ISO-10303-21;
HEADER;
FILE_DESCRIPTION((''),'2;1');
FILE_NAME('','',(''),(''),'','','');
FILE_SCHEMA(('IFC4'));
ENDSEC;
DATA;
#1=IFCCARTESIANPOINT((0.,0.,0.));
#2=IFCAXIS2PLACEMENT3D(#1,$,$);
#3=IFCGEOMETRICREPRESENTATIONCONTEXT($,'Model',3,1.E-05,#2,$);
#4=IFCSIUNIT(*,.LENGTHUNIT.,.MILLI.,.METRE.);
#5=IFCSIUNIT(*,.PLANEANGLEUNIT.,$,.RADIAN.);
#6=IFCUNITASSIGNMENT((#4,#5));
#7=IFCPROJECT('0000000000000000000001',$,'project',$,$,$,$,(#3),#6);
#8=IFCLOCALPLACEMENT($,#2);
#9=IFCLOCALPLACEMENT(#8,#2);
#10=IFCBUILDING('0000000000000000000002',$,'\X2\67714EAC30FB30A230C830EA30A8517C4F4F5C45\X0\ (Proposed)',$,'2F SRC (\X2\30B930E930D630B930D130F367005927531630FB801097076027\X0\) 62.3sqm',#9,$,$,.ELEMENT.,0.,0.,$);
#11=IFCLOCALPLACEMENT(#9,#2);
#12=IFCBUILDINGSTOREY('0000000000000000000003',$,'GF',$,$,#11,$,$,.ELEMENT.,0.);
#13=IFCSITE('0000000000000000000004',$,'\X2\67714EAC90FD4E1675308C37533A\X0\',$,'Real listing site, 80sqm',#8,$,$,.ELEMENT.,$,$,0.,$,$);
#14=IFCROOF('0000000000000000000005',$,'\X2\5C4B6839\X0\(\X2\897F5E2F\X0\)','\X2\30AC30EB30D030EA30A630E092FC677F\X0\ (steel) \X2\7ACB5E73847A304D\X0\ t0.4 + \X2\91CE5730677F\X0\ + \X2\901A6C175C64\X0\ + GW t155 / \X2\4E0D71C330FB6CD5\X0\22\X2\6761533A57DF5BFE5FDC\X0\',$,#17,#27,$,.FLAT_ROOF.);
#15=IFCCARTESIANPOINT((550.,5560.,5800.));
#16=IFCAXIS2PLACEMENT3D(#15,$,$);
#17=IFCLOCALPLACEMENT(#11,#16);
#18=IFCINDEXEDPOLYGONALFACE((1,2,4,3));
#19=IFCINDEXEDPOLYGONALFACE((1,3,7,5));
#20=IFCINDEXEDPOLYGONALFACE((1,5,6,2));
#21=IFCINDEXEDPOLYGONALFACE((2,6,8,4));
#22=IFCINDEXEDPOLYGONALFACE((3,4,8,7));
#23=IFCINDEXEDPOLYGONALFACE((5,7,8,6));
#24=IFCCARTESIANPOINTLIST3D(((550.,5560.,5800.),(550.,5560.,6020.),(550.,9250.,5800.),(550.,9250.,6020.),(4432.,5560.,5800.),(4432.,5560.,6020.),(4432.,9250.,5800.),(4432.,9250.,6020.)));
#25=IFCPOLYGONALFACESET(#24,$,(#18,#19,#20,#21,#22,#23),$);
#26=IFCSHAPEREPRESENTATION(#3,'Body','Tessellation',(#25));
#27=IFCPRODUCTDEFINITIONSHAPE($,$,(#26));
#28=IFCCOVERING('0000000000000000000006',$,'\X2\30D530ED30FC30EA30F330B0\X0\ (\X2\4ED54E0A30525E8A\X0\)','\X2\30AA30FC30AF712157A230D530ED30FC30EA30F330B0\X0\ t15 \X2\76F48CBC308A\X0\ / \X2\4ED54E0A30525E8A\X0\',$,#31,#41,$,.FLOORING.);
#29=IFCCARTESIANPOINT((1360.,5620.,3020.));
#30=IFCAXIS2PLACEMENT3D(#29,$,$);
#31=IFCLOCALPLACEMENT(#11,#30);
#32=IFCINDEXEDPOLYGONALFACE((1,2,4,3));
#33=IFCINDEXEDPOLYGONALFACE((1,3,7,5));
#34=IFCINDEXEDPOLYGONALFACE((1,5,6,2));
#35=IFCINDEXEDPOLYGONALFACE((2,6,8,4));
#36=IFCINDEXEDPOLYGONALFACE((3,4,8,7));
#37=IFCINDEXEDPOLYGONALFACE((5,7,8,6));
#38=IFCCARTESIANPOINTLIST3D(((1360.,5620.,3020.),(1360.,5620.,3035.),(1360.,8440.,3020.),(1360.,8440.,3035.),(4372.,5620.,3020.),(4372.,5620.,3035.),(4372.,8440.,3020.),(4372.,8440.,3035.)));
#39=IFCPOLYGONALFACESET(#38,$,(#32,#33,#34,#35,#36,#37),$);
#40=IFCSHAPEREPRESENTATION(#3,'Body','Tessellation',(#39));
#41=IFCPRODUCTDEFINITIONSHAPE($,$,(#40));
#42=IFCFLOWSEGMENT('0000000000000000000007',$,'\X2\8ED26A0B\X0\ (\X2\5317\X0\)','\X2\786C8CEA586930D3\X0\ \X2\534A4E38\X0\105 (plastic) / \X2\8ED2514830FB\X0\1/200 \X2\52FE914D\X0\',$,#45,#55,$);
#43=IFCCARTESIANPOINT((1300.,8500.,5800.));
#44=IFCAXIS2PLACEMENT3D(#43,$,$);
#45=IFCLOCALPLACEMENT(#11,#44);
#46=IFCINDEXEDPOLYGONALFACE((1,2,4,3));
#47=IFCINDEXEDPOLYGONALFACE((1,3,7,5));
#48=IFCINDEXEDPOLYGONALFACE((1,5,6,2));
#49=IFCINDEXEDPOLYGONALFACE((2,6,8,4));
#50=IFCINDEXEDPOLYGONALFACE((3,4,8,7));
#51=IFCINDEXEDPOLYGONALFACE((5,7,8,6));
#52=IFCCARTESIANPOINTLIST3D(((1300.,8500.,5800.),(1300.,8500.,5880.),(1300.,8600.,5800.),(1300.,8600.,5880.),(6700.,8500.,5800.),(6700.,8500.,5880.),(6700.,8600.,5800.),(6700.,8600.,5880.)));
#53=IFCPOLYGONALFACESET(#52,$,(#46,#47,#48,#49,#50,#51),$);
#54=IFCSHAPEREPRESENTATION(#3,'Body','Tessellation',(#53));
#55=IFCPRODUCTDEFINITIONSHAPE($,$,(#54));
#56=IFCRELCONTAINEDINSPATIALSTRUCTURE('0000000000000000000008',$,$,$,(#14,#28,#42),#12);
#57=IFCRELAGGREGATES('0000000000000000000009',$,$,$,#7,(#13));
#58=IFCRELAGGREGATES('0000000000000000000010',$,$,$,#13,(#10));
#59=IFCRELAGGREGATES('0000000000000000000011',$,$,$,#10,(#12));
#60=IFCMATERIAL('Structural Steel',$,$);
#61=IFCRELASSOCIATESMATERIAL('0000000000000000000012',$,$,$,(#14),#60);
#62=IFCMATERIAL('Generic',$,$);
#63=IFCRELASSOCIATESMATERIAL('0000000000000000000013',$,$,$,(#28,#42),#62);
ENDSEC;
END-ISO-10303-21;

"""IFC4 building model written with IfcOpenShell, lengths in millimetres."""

from ifc_helpers import new_model, si_unit, frame, frame_2d, origin, place, context, project, spatial, rectangle, extrude, material, element, save


model = new_model("IFC4")

# Units and contexts
model_context = context("Model", 3, precision=1e-05, world=origin())
ifc_project = project(units=[si_unit("LENGTHUNIT", "METRE", prefix="MILLI"), si_unit("PLANEANGLEUNIT", "RADIAN")], contexts=[model_context])

# Site, building, storey
site_placement = place(None, origin())
site = spatial("IfcSite", under=ifc_project, at=site_placement, Name="東京都世田谷区", ObjectType="Real listing site, 80sqm", CompositionType="ELEMENT", RefElevation=0.0)
building_placement = place(site_placement, origin())
building = spatial("IfcBuilding", under=site, at=building_placement, Name="東京・アトリエ兼住居 (Proposed)", ObjectType="2F SRC (スラブスパン最大化・耐震性) 62.3sqm", CompositionType="ELEMENT", ElevationOfRefHeight=0.0, ElevationOfTerrain=0.0)
storey_placement = place(building_placement, origin())
storey = spatial("IfcBuildingStorey", under=building, at=storey_placement, Name="GF", CompositionType="ELEMENT", Elevation=0.0)

# Roof
ifc_material_1 = material(Name="Structural Steel")
for number, where, name in (
    (1, (550.0, 5560.0, 5800.0), "屋根(西帯)"),
):
    element("IfcRoof", number, at=place(storey_placement, frame(where)), inside=storey, material=ifc_material_1, Name=name, Description="ガルバリウム鋼板 (steel) 立平葺き t0.4 + 野地板 + 通気層 + GW t155 / 不燃・法22条区域対応", PredefinedType="FLAT_ROOF", context=model_context, shape_type="SweptSolid", body=[
        extrude(rectangle(XDim=3882.0, YDim=3690.0, at=frame_2d((1941.0, 1845.0))), frame((550.0, 5560.0, 5800.0)), (0.0, 0.0, 1.0), 220.0),
    ])

# Covering
ifc_material_2 = material(Name="Generic")
covering_placement = place(storey_placement, frame((1360.0, 5620.0, 3020.0)))
element("IfcCovering", 2, at=covering_placement, inside=storey, material=ifc_material_2, Name="フローリング (仕上げ床)", Description="オーク無垢フローリング t15 直貼り / 仕上げ床", PredefinedType="FLOORING", context=model_context, shape_type="SweptSolid", body=[
    extrude(rectangle(XDim=3012.0, YDim=2820.0, at=frame_2d((1506.0, 1410.0))), frame((1360.0, 5620.0, 3020.0)), (0.0, 0.0, 1.0), 15.0),
])

# Flow segment
flow_segment_placement = place(storey_placement, frame((1300.0, 8500.0, 5800.0)))
element("IfcFlowSegment", 3, at=flow_segment_placement, inside=storey, material=ifc_material_2, Name="軒樋 (北)", Description="硬質塩ビ 半丸105 (plastic) / 軒先・1/200 勾配", context=model_context, shape_type="SweptSolid", body=[
    extrude(rectangle(XDim=5400.0, YDim=100.0, at=frame_2d((2700.0, 50.0))), frame((1300.0, 8500.0, 5800.0)), (0.0, 0.0, 1.0), 80.0),
])

save(model, "model.ifc")
